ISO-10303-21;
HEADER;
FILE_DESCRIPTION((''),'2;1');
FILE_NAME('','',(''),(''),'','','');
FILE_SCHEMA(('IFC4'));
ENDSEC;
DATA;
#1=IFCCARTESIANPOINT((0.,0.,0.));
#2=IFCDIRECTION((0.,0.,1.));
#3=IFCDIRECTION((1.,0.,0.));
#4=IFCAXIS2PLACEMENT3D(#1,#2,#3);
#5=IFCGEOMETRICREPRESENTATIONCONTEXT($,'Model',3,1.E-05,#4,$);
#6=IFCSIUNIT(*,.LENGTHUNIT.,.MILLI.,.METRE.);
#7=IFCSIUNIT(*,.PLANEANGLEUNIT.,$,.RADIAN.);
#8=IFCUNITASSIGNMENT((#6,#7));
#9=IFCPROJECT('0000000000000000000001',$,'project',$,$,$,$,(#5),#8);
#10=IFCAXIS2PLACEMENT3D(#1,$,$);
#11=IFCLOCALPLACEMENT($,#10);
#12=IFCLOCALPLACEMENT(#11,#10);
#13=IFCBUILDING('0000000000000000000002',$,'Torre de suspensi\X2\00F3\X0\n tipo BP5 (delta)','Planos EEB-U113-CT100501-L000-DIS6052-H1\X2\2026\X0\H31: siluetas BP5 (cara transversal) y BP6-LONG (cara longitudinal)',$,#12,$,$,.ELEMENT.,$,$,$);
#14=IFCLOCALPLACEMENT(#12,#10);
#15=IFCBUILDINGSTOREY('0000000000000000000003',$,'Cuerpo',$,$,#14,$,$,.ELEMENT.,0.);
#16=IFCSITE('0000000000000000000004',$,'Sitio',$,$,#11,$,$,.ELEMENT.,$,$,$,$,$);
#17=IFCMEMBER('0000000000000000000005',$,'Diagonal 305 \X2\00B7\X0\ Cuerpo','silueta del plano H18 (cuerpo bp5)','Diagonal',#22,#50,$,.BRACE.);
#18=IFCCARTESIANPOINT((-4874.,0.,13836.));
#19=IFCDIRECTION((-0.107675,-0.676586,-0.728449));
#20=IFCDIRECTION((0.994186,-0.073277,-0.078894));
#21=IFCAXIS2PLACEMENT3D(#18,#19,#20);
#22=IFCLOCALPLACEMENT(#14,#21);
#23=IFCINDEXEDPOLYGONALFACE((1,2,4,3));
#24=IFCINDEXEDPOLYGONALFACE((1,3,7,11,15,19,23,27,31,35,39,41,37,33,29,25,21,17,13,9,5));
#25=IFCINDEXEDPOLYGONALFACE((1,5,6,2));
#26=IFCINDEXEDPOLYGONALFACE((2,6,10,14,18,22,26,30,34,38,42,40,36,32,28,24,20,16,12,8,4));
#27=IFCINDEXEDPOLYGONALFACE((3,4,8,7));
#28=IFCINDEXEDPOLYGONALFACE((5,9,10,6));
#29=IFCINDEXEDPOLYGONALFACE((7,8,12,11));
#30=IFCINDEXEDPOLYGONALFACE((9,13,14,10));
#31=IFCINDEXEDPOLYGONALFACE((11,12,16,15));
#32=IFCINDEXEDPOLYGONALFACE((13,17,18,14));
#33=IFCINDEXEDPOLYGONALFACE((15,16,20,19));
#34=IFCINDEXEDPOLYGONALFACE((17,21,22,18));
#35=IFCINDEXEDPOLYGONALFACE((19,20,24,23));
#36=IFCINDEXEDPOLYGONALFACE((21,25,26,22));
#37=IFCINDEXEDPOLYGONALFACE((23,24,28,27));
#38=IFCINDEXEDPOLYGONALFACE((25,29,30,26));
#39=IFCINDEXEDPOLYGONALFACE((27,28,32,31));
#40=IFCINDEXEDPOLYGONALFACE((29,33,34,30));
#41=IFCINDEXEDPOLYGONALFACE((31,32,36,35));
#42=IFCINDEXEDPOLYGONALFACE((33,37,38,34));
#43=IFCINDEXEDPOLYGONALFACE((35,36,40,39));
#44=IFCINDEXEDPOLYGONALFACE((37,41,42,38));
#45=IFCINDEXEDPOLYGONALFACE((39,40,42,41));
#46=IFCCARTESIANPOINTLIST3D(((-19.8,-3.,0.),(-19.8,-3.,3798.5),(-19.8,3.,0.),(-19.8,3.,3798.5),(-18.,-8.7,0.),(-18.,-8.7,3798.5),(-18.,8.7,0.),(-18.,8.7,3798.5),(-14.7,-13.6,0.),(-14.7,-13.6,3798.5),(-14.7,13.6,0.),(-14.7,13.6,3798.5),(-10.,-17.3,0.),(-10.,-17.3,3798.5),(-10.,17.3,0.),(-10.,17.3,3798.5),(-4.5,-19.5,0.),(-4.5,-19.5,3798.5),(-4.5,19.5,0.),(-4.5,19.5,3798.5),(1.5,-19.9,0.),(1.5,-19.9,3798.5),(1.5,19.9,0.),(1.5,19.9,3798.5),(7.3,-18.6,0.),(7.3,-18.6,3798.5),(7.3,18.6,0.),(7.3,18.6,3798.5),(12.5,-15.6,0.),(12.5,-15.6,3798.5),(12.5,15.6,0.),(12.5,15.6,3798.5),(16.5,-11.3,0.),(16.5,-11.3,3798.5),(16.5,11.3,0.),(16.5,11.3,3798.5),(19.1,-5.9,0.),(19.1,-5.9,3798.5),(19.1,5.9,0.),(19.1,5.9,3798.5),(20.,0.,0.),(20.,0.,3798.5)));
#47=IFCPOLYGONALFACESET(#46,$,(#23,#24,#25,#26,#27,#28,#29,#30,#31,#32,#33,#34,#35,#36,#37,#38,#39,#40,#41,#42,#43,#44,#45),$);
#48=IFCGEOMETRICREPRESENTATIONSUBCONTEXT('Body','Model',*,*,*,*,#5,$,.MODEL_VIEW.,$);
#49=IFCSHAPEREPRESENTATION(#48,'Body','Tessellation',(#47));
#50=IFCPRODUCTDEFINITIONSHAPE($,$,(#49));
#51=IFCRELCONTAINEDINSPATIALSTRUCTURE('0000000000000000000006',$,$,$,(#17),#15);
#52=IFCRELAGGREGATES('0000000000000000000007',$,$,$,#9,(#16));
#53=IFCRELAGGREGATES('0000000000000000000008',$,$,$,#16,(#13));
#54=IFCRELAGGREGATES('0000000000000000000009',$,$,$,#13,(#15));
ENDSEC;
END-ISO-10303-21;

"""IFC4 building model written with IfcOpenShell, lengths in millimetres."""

from ifc_helpers import new_model, si_unit, frame, origin, origin_with_axes, place, context, subcontext, project, spatial, circle, extrude, element, save


model = new_model("IFC4")

# Units and contexts
model_context = context("Model", 3, precision=1e-05, world=origin_with_axes())
body_context = subcontext(model_context, "Body", "Model", "MODEL_VIEW")
ifc_project = project(units=[si_unit("LENGTHUNIT", "METRE", prefix="MILLI"), si_unit("PLANEANGLEUNIT", "RADIAN")], contexts=[model_context])

# Site, building, storey
site_placement = place(None, origin())
site = spatial("IfcSite", under=ifc_project, at=site_placement, Name="Sitio", CompositionType="ELEMENT")
building_placement = place(site_placement, origin())
building = spatial("IfcBuilding", under=site, at=building_placement, Name="Torre de suspensión tipo BP5 (delta)", Description="Planos EEB-U113-CT100501-L000-DIS6052-H1…H31: siluetas BP5 (cara transversal) y BP6-LONG (cara longitudinal)", CompositionType="ELEMENT")
storey_placement = place(building_placement, origin())
storey = spatial("IfcBuildingStorey", under=building, at=storey_placement, Name="Cuerpo", CompositionType="ELEMENT", Elevation=0.0)

# Member
member_1_placement = place(storey_placement, frame((-4874.0, 0.0, 13836.0), z_axis=(-0.107675, -0.676586, -0.728449), x_axis=(0.994186, -0.073277, -0.078894)))
element("IfcMember", 1, at=member_1_placement, inside=storey, Name="Diagonal 305 · Cuerpo", Description="silueta del plano H18 (cuerpo bp5)", ObjectType="Diagonal", PredefinedType="BRACE", context=body_context, shape_type="SweptSolid", body=[
    extrude(circle(Radius=20.0), None, (0.0, 0.0, 1.0), 3798.5),
])

save(model, "model.ifc")
